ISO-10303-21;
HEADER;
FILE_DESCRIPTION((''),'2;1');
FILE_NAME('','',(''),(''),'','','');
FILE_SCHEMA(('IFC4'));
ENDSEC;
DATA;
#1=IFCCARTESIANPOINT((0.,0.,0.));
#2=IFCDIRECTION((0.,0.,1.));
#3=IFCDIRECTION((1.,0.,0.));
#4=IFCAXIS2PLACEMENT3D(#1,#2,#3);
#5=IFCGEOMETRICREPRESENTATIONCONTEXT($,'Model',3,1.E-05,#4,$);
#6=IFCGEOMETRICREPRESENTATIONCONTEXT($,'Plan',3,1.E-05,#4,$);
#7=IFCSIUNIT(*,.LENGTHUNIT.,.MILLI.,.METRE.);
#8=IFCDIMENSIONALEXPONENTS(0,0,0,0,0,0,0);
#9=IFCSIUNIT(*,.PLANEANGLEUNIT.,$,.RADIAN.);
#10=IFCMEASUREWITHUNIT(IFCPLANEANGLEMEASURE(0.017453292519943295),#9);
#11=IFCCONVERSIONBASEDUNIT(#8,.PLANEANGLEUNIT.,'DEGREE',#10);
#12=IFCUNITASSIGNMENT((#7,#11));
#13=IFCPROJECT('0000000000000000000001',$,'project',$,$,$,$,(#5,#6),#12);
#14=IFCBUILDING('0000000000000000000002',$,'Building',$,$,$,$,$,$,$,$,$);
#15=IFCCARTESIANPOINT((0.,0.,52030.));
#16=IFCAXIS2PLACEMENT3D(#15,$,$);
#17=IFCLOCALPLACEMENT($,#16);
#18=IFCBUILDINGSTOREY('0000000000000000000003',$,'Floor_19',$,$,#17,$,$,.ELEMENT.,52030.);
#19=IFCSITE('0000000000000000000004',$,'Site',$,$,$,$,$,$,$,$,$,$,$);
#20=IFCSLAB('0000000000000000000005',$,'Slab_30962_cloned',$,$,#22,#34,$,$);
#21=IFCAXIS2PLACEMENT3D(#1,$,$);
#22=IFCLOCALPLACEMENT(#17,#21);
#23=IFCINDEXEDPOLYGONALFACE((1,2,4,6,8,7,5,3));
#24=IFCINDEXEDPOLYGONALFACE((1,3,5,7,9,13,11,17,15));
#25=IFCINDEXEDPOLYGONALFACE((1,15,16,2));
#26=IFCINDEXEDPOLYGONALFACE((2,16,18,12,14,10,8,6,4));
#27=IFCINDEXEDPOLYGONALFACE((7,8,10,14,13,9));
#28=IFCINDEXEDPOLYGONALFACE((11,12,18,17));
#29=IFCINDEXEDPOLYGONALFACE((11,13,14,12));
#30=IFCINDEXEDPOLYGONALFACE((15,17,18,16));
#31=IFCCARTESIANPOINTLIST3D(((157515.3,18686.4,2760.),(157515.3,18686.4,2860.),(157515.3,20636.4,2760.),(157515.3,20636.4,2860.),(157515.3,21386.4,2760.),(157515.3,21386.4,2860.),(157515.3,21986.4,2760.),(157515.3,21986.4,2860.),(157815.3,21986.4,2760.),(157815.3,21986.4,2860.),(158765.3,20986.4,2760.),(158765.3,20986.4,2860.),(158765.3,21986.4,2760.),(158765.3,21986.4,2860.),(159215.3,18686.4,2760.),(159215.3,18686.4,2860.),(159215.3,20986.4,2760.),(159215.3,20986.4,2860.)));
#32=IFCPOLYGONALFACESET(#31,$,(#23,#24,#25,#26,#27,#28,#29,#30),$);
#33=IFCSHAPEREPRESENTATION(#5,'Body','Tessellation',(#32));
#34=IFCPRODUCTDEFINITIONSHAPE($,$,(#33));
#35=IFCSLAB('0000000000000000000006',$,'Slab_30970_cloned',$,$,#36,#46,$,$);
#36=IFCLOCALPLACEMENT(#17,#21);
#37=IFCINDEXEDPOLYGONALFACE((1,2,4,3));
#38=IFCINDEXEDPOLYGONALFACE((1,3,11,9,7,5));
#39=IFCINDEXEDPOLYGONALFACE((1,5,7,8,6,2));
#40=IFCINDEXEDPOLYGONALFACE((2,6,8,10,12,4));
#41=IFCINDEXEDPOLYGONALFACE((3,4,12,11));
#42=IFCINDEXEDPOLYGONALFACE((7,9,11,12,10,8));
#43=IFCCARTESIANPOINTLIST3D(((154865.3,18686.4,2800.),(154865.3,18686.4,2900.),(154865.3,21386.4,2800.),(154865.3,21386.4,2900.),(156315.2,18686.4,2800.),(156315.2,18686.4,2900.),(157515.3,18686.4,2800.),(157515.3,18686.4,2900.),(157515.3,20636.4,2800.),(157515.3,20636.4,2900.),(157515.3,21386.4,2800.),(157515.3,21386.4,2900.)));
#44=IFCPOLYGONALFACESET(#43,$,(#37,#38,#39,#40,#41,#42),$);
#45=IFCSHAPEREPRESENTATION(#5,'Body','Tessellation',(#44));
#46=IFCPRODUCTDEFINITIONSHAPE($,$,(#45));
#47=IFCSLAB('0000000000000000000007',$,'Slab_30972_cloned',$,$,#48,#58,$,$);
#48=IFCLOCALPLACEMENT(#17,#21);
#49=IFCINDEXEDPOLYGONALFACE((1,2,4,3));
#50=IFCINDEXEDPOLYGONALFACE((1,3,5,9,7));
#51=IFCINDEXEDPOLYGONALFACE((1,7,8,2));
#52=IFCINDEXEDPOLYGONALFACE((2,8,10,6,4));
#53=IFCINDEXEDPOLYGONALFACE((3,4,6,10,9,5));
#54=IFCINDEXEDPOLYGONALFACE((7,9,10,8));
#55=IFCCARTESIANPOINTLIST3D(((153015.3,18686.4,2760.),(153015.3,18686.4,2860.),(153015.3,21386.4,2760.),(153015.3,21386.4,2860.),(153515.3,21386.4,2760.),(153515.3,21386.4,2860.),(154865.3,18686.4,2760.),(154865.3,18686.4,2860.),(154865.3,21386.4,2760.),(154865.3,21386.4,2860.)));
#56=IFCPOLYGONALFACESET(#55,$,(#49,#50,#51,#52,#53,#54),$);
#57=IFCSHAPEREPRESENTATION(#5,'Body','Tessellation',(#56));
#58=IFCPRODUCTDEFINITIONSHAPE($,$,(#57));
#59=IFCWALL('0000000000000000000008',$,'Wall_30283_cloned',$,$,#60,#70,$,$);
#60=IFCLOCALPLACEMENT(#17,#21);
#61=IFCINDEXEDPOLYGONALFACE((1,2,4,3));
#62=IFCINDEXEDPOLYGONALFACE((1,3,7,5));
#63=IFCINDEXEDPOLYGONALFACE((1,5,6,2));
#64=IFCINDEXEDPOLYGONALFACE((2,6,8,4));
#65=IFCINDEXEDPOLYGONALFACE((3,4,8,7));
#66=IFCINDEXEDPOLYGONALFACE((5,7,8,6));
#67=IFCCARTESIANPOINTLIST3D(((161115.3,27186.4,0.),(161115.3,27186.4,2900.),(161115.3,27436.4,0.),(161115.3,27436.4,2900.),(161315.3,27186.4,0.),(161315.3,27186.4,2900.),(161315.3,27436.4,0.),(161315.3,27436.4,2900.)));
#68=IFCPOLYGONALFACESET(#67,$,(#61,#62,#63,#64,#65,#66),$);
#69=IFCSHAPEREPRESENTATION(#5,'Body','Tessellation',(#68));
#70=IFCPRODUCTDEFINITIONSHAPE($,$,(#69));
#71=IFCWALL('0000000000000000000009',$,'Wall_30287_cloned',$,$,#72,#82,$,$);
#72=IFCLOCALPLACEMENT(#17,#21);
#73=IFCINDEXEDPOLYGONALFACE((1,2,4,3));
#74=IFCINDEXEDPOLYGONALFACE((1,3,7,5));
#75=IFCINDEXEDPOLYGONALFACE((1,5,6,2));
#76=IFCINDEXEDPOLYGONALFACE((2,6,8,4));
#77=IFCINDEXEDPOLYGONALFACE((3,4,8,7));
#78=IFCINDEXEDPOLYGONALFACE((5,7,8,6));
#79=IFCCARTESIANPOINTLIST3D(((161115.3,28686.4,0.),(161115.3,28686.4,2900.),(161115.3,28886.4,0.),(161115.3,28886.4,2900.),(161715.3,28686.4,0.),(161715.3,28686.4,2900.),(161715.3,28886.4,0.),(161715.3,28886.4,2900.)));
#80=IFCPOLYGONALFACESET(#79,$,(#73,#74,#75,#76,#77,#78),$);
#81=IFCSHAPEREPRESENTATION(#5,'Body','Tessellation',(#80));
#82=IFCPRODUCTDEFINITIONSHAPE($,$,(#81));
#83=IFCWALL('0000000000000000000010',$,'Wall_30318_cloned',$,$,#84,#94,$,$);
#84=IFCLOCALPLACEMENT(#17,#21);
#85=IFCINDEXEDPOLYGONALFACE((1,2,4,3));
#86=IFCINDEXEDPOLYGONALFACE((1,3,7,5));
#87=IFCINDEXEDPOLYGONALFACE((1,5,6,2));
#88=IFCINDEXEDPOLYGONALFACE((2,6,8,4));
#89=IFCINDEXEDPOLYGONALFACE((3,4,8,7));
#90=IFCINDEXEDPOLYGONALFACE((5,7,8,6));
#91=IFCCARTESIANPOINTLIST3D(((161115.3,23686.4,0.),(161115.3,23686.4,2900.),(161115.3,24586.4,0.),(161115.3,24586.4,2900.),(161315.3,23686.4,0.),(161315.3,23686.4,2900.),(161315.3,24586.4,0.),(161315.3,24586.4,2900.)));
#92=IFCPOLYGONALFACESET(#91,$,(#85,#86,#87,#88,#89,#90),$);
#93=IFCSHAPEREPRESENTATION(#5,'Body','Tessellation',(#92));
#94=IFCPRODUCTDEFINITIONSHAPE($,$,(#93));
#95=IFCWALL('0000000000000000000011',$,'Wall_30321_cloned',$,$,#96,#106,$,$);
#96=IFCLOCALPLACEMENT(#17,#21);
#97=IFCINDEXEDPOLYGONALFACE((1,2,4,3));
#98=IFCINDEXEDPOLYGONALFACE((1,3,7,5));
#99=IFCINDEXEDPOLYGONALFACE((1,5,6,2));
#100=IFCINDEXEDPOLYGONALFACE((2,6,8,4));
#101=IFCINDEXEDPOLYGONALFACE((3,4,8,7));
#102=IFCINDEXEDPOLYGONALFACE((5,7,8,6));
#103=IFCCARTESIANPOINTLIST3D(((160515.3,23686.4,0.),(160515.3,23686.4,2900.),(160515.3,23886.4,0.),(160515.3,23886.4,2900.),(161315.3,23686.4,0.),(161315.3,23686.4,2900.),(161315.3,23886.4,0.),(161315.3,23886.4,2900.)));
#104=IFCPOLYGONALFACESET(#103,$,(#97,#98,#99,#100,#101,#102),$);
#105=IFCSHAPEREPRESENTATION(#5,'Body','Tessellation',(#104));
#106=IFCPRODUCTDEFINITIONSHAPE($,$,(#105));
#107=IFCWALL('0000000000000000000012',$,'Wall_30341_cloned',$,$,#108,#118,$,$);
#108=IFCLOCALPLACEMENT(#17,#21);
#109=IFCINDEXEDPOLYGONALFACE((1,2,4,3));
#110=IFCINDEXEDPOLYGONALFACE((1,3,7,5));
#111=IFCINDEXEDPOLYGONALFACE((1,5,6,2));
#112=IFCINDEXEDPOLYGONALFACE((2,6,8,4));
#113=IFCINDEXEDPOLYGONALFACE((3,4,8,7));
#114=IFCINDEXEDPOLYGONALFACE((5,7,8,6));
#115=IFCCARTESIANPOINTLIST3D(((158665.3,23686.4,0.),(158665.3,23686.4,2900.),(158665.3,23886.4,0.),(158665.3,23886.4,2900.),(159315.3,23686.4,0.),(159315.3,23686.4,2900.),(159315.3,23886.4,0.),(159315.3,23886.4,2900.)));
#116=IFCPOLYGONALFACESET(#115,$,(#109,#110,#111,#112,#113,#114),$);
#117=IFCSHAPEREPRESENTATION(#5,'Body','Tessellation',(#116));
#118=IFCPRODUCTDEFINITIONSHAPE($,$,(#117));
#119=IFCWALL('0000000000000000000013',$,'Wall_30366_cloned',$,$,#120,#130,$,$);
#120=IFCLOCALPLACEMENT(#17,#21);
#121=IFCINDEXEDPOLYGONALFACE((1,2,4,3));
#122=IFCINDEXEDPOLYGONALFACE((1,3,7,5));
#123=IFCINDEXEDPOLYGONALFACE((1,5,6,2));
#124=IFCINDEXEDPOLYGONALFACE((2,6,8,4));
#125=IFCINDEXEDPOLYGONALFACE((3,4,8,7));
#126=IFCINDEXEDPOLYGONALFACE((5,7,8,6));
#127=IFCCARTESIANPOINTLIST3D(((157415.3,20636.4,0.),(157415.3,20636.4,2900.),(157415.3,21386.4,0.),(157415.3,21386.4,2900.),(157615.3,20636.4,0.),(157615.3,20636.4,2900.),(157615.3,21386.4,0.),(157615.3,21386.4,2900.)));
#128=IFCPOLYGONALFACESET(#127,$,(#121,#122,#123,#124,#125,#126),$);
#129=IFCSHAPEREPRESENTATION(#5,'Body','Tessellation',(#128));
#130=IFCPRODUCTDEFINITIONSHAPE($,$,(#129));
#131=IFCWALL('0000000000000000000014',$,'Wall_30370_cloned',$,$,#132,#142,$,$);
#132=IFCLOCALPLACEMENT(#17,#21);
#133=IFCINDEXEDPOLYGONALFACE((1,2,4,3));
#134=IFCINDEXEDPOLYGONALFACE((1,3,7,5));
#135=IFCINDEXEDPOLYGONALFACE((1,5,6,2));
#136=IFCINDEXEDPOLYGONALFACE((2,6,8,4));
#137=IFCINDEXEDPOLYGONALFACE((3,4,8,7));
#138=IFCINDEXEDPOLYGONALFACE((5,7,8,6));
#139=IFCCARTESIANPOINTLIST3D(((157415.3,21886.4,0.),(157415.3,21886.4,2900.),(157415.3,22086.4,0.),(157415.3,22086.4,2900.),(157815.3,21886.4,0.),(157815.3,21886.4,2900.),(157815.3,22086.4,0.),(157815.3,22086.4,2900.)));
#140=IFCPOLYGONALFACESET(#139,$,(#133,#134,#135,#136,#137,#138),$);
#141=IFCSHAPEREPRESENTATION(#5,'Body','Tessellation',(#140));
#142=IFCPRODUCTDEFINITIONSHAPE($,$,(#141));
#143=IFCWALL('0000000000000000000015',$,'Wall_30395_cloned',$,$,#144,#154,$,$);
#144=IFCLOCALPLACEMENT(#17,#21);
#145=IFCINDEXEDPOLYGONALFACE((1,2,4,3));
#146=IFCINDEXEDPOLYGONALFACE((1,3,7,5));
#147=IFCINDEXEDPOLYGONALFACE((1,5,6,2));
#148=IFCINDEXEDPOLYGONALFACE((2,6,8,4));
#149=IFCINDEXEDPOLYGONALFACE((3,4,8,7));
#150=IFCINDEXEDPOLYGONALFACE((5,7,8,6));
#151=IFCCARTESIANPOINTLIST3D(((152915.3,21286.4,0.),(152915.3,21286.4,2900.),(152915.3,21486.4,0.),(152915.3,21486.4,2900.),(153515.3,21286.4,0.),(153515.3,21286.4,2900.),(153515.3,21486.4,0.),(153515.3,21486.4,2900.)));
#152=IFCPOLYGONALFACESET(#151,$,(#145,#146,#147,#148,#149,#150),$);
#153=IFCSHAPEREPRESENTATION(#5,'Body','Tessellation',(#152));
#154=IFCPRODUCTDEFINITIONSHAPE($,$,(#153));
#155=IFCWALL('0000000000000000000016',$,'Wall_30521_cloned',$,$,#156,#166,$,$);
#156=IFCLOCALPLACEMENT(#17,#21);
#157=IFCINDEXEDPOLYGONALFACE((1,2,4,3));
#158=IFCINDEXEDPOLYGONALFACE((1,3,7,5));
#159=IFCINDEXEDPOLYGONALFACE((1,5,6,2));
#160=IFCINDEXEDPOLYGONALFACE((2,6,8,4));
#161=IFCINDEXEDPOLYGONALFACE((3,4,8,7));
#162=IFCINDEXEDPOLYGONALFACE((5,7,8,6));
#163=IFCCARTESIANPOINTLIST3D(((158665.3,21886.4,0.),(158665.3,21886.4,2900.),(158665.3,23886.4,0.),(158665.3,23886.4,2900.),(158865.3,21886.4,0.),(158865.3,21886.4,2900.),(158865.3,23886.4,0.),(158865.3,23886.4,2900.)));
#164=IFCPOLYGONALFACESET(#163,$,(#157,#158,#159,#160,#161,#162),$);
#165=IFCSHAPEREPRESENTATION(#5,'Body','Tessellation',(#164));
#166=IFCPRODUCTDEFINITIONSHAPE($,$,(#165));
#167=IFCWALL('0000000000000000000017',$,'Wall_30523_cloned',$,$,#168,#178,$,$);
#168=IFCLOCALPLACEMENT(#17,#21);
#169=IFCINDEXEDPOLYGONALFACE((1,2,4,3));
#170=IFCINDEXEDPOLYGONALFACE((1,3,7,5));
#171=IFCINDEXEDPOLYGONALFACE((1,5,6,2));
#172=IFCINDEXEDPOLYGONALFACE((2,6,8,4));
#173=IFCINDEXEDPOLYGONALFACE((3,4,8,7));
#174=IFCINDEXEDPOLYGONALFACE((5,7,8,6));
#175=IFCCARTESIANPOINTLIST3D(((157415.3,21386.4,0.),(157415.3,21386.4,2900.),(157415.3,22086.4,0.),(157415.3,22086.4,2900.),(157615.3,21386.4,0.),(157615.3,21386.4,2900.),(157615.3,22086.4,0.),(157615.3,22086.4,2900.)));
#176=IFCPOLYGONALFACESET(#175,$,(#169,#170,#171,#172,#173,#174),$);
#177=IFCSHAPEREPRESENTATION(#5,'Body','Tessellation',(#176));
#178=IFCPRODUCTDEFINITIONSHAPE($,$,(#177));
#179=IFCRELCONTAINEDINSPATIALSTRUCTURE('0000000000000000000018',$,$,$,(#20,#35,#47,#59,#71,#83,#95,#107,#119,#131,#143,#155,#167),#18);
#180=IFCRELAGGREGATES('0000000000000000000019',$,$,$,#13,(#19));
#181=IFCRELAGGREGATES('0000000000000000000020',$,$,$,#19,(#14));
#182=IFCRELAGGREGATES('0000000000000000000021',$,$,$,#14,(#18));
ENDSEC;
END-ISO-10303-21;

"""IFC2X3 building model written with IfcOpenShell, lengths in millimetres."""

from ifc_helpers import new_model, entity, si_unit, converted_unit, frame, origin_with_axes, origin_2d, place, context, project, spatial, polyline, rectangle, outline, extrude, source, transform, mapped, element, save


model = new_model("IFC2X3")

# Units and contexts
model_context = context("Model", 3, precision=1e-05, world=origin_with_axes())
plan_context = context("Plan", 3, precision=1e-05, world=origin_with_axes())
ifc_project = project(units=[si_unit("LENGTHUNIT", "METRE", prefix="MILLI"), converted_unit("PLANEANGLEUNIT", "DEGREE", entity("IfcPlaneAngleMeasure", 0.017453292519943295), si_unit("PLANEANGLEUNIT", "RADIAN"), dimensions=[0, 0, 0, 0, 0, 0, 0])], contexts=[model_context, plan_context])

# Site, building, storey
site = spatial("IfcSite", under=ifc_project, Name="Site")
building = spatial("IfcBuilding", under=site, Name="Building")
storey_placement = place(None, frame((0.0, 0.0, 52030.0)))
storey = spatial("IfcBuildingStorey", under=building, at=storey_placement, Name="Floor_19", CompositionType="ELEMENT", Elevation=52030.0)

# Slabs
shared_shape_1 = source(origin_with_axes(), model_context, "Body", "SweptSolid", [
    extrude(outline(polyline([(0.0, 0.0), (950.0, 0.0), (1250.0, 0.0), (1250.0, 600.0), (1250.0, 1350.0), (1250.0, 3300.0), (-450.0, 3300.0), (-450.0, 1000.0), (0.0, 1000.0)])), origin_with_axes(), (0.0, 0.0, 1.0), 100.0),
])
slab_1_placement = place(storey_placement, frame((158765.3, 21986.4, 2760.0), z_axis=(0.0, 0.0, 1.0), x_axis=(-950.0, 0.0, 0.0)))
element("IfcSlab", 1, at=slab_1_placement, inside=storey, Name="Slab_30962_cloned", context=model_context, shape_type="MappedRepresentation", body=[
    mapped(shared_shape_1, transform((0.0, 0.0, 0.0), x_axis=(1.0, 0.0, 0.0), y_axis=(0.0, 1.0, 0.0), z_axis=(0.0, 0.0, 1.0), scale=1.0)),
])
shared_shape_2 = source(origin_with_axes(), model_context, "Body", "SweptSolid", [
    extrude(outline(polyline([(0.0, 0.0), (2700.0, 0.0), (2700.0, 1449.9), (2700.0, 2650.0), (750.0, 2650.0), (0.0, 2650.0)])), origin_with_axes(), (0.0, 0.0, 1.0), 100.0),
])
slab_2_placement = place(storey_placement, frame((154865.3, 21386.4, 2800.0), z_axis=(0.0, 0.0, 1.0), x_axis=(0.0, -2700.0, 0.0)))
element("IfcSlab", 2, at=slab_2_placement, inside=storey, Name="Slab_30970_cloned", context=model_context, shape_type="MappedRepresentation", body=[
    mapped(shared_shape_2, transform((0.0, 0.0, 0.0), x_axis=(1.0, 0.0, 0.0), y_axis=(0.0, 1.0, 0.0), z_axis=(0.0, 0.0, 1.0), scale=1.0)),
])
shared_shape_3 = source(origin_with_axes(), model_context, "Body", "SweptSolid", [
    extrude(outline(polyline([(0.0, 0.0), (2700.0, 0.0), (2700.0, 1850.0), (0.0, 1850.0), (0.0, 500.0)])), origin_with_axes(), (0.0, 0.0, 1.0), 100.0),
])
slab_3_placement = place(storey_placement, frame((153015.3, 21386.4, 2760.0), z_axis=(0.0, 0.0, 1.0), x_axis=(0.0, -2700.0, 0.0)))
element("IfcSlab", 3, at=slab_3_placement, inside=storey, Name="Slab_30972_cloned", context=model_context, shape_type="MappedRepresentation", body=[
    mapped(shared_shape_3, transform((0.0, 0.0, 0.0), x_axis=(1.0, 0.0, 0.0), y_axis=(0.0, 1.0, 0.0), z_axis=(0.0, 0.0, 1.0), scale=1.0)),
])

# Walls
shared_shape_4 = source(origin_with_axes(), model_context, "Body", "SweptSolid", [
    extrude(rectangle(XDim=250.0, YDim=200.0, at=origin_2d()), origin_with_axes(), (0.0, 0.0, 1.0), 2900.0),
])
wall_1_placement = place(storey_placement, frame((161215.3, 27311.4, 0.0), z_axis=(0.0, 0.0, 1.0), x_axis=(0.0, 249.999994, 0.0)))
element("IfcWall", 4, at=wall_1_placement, inside=storey, Name="Wall_30283_cloned", context=model_context, shape_type="MappedRepresentation", body=[
    mapped(shared_shape_4, transform((0.0, 0.0, 0.0), x_axis=(1.0, 0.0, 0.0), y_axis=(0.0, 1.0, 0.0), z_axis=(0.0, 0.0, 1.0), scale=1.0)),
])
shared_shape_5 = source(origin_with_axes(), model_context, "Body", "SweptSolid", [
    extrude(rectangle(XDim=600.0, YDim=200.0, at=origin_2d()), origin_with_axes(), (0.0, 0.0, 1.0), 2900.0),
])
wall_2_placement = place(storey_placement, frame((161415.3, 28786.4, 0.0), z_axis=(0.0, 0.0, 1.0), x_axis=(600.00002, 0.0, 0.0)))
element("IfcWall", 5, at=wall_2_placement, inside=storey, Name="Wall_30287_cloned", context=model_context, shape_type="MappedRepresentation", body=[
    mapped(shared_shape_5, transform((0.0, 0.0, 0.0), x_axis=(1.0, 0.0, 0.0), y_axis=(0.0, 1.0, 0.0), z_axis=(0.0, 0.0, 1.0), scale=1.0)),
])
shared_shape_6 = source(origin_with_axes(), model_context, "Body", "SweptSolid", [
    extrude(rectangle(XDim=900.0, YDim=200.0, at=origin_2d()), origin_with_axes(), (0.0, 0.0, 1.0), 2900.0),
])
wall_3_placement = place(storey_placement, frame((161215.3, 24136.4, 0.0), z_axis=(0.0, 0.0, 1.0), x_axis=(0.0, 900.0, 0.0)))
element("IfcWall", 6, at=wall_3_placement, inside=storey, Name="Wall_30318_cloned", context=model_context, shape_type="MappedRepresentation", body=[
    mapped(shared_shape_6, transform((0.0, 0.0, 0.0), x_axis=(1.0, 0.0, 0.0), y_axis=(0.0, 1.0, 0.0), z_axis=(0.0, 0.0, 1.0), scale=1.0)),
])
shared_shape_7 = source(origin_with_axes(), model_context, "Body", "SweptSolid", [
    extrude(rectangle(XDim=800.0, YDim=200.0, at=origin_2d()), origin_with_axes(), (0.0, 0.0, 1.0), 2900.0),
])
wall_4_placement = place(storey_placement, frame((160915.3, 23786.4, 0.0), z_axis=(0.0, 0.0, 1.0), x_axis=(800.0, 0.0, 0.0)))
element("IfcWall", 7, at=wall_4_placement, inside=storey, Name="Wall_30321_cloned", context=model_context, shape_type="MappedRepresentation", body=[
    mapped(shared_shape_7, transform((0.0, 0.0, 0.0), x_axis=(1.0, 0.0, 0.0), y_axis=(0.0, 1.0, 0.0), z_axis=(0.0, 0.0, 1.0), scale=1.0)),
])
shared_shape_8 = source(origin_with_axes(), model_context, "Body", "SweptSolid", [
    extrude(rectangle(XDim=650.0, YDim=200.0, at=origin_2d()), origin_with_axes(), (0.0, 0.0, 1.0), 2900.0),
])
wall_5_placement = place(storey_placement, frame((158990.3, 23786.4, 0.0), z_axis=(0.0, 0.0, 1.0), x_axis=(650.0, 0.0, 0.0)))
element("IfcWall", 8, at=wall_5_placement, inside=storey, Name="Wall_30341_cloned", context=model_context, shape_type="MappedRepresentation", body=[
    mapped(shared_shape_8, transform((0.0, 0.0, 0.0), x_axis=(1.0, 0.0, 0.0), y_axis=(0.0, 1.0, 0.0), z_axis=(0.0, 0.0, 1.0), scale=1.0)),
])
shared_shape_9 = source(origin_with_axes(), model_context, "Body", "SweptSolid", [
    extrude(rectangle(XDim=750.0, YDim=200.0, at=origin_2d()), origin_with_axes(), (0.0, 0.0, 1.0), 2900.0),
])
wall_6_placement = place(storey_placement, frame((157515.3, 21011.4, 0.0), z_axis=(0.0, 0.0, 1.0), x_axis=(0.0, 750.0, 0.0)))
element("IfcWall", 9, at=wall_6_placement, inside=storey, Name="Wall_30366_cloned", context=model_context, shape_type="MappedRepresentation", body=[
    mapped(shared_shape_9, transform((0.0, 0.0, 0.0), x_axis=(1.0, 0.0, 0.0), y_axis=(0.0, 1.0, 0.0), z_axis=(0.0, 0.0, 1.0), scale=1.0)),
])
shared_shape_10 = source(origin_with_axes(), model_context, "Body", "SweptSolid", [
    extrude(rectangle(XDim=400.0, YDim=200.0, at=origin_2d()), origin_with_axes(), (0.0, 0.0, 1.0), 2900.0),
])
wall_7_placement = place(storey_placement, frame((157615.3, 21986.4, 0.0), z_axis=(0.0, 0.0, 1.0), x_axis=(400.0, 0.0, 0.0)))
element("IfcWall", 10, at=wall_7_placement, inside=storey, Name="Wall_30370_cloned", context=model_context, shape_type="MappedRepresentation", body=[
    mapped(shared_shape_10, transform((0.0, 0.0, 0.0), x_axis=(1.0, 0.0, 0.0), y_axis=(0.0, 1.0, 0.0), z_axis=(0.0, 0.0, 1.0), scale=1.0)),
])
shared_shape_11 = source(origin_with_axes(), model_context, "Body", "SweptSolid", [
    extrude(rectangle(XDim=600.0, YDim=200.0, at=origin_2d()), origin_with_axes(), (0.0, 0.0, 1.0), 2900.0),
])
wall_8_placement = place(storey_placement, frame((153215.3, 21386.4, 0.0), z_axis=(0.0, 0.0, 1.0), x_axis=(600.0, 0.0, 0.0)))
element("IfcWall", 11, at=wall_8_placement, inside=storey, Name="Wall_30395_cloned", context=model_context, shape_type="MappedRepresentation", body=[
    mapped(shared_shape_11, transform((0.0, 0.0, 0.0), x_axis=(1.0, 0.0, 0.0), y_axis=(0.0, 1.0, 0.0), z_axis=(0.0, 0.0, 1.0), scale=1.0)),
])
shared_shape_12 = source(origin_with_axes(), model_context, "Body", "SweptSolid", [
    extrude(rectangle(XDim=2000.0, YDim=200.0, at=origin_2d()), origin_with_axes(), (0.0, 0.0, 1.0), 2900.0),
])
wall_9_placement = place(storey_placement, frame((158765.3, 22886.4, 0.0), z_axis=(0.0, 0.0, 1.0), x_axis=(0.0, 2000.0, 0.0)))
element("IfcWall", 12, at=wall_9_placement, inside=storey, Name="Wall_30521_cloned", context=model_context, shape_type="MappedRepresentation", body=[
    mapped(shared_shape_12, transform((0.0, 0.0, 0.0), x_axis=(1.0, 0.0, 0.0), y_axis=(0.0, 1.0, 0.0), z_axis=(0.0, 0.0, 1.0), scale=1.0)),
])
shared_shape_13 = source(origin_with_axes(), model_context, "Body", "SweptSolid", [
    extrude(rectangle(XDim=700.0, YDim=200.0, at=origin_2d()), origin_with_axes(), (0.0, 0.0, 1.0), 2900.0),
])
wall_10_placement = place(storey_placement, frame((157515.3, 21736.4, 0.0), z_axis=(0.0, 0.0, 1.0), x_axis=(0.0, 700.0, 0.0)))
element("IfcWall", 13, at=wall_10_placement, inside=storey, Name="Wall_30523_cloned", context=model_context, shape_type="MappedRepresentation", body=[
    mapped(shared_shape_13, transform((0.0, 0.0, 0.0), x_axis=(1.0, 0.0, 0.0), y_axis=(0.0, 1.0, 0.0), z_axis=(0.0, 0.0, 1.0), scale=1.0)),
])

save(model, "model.ifc")
